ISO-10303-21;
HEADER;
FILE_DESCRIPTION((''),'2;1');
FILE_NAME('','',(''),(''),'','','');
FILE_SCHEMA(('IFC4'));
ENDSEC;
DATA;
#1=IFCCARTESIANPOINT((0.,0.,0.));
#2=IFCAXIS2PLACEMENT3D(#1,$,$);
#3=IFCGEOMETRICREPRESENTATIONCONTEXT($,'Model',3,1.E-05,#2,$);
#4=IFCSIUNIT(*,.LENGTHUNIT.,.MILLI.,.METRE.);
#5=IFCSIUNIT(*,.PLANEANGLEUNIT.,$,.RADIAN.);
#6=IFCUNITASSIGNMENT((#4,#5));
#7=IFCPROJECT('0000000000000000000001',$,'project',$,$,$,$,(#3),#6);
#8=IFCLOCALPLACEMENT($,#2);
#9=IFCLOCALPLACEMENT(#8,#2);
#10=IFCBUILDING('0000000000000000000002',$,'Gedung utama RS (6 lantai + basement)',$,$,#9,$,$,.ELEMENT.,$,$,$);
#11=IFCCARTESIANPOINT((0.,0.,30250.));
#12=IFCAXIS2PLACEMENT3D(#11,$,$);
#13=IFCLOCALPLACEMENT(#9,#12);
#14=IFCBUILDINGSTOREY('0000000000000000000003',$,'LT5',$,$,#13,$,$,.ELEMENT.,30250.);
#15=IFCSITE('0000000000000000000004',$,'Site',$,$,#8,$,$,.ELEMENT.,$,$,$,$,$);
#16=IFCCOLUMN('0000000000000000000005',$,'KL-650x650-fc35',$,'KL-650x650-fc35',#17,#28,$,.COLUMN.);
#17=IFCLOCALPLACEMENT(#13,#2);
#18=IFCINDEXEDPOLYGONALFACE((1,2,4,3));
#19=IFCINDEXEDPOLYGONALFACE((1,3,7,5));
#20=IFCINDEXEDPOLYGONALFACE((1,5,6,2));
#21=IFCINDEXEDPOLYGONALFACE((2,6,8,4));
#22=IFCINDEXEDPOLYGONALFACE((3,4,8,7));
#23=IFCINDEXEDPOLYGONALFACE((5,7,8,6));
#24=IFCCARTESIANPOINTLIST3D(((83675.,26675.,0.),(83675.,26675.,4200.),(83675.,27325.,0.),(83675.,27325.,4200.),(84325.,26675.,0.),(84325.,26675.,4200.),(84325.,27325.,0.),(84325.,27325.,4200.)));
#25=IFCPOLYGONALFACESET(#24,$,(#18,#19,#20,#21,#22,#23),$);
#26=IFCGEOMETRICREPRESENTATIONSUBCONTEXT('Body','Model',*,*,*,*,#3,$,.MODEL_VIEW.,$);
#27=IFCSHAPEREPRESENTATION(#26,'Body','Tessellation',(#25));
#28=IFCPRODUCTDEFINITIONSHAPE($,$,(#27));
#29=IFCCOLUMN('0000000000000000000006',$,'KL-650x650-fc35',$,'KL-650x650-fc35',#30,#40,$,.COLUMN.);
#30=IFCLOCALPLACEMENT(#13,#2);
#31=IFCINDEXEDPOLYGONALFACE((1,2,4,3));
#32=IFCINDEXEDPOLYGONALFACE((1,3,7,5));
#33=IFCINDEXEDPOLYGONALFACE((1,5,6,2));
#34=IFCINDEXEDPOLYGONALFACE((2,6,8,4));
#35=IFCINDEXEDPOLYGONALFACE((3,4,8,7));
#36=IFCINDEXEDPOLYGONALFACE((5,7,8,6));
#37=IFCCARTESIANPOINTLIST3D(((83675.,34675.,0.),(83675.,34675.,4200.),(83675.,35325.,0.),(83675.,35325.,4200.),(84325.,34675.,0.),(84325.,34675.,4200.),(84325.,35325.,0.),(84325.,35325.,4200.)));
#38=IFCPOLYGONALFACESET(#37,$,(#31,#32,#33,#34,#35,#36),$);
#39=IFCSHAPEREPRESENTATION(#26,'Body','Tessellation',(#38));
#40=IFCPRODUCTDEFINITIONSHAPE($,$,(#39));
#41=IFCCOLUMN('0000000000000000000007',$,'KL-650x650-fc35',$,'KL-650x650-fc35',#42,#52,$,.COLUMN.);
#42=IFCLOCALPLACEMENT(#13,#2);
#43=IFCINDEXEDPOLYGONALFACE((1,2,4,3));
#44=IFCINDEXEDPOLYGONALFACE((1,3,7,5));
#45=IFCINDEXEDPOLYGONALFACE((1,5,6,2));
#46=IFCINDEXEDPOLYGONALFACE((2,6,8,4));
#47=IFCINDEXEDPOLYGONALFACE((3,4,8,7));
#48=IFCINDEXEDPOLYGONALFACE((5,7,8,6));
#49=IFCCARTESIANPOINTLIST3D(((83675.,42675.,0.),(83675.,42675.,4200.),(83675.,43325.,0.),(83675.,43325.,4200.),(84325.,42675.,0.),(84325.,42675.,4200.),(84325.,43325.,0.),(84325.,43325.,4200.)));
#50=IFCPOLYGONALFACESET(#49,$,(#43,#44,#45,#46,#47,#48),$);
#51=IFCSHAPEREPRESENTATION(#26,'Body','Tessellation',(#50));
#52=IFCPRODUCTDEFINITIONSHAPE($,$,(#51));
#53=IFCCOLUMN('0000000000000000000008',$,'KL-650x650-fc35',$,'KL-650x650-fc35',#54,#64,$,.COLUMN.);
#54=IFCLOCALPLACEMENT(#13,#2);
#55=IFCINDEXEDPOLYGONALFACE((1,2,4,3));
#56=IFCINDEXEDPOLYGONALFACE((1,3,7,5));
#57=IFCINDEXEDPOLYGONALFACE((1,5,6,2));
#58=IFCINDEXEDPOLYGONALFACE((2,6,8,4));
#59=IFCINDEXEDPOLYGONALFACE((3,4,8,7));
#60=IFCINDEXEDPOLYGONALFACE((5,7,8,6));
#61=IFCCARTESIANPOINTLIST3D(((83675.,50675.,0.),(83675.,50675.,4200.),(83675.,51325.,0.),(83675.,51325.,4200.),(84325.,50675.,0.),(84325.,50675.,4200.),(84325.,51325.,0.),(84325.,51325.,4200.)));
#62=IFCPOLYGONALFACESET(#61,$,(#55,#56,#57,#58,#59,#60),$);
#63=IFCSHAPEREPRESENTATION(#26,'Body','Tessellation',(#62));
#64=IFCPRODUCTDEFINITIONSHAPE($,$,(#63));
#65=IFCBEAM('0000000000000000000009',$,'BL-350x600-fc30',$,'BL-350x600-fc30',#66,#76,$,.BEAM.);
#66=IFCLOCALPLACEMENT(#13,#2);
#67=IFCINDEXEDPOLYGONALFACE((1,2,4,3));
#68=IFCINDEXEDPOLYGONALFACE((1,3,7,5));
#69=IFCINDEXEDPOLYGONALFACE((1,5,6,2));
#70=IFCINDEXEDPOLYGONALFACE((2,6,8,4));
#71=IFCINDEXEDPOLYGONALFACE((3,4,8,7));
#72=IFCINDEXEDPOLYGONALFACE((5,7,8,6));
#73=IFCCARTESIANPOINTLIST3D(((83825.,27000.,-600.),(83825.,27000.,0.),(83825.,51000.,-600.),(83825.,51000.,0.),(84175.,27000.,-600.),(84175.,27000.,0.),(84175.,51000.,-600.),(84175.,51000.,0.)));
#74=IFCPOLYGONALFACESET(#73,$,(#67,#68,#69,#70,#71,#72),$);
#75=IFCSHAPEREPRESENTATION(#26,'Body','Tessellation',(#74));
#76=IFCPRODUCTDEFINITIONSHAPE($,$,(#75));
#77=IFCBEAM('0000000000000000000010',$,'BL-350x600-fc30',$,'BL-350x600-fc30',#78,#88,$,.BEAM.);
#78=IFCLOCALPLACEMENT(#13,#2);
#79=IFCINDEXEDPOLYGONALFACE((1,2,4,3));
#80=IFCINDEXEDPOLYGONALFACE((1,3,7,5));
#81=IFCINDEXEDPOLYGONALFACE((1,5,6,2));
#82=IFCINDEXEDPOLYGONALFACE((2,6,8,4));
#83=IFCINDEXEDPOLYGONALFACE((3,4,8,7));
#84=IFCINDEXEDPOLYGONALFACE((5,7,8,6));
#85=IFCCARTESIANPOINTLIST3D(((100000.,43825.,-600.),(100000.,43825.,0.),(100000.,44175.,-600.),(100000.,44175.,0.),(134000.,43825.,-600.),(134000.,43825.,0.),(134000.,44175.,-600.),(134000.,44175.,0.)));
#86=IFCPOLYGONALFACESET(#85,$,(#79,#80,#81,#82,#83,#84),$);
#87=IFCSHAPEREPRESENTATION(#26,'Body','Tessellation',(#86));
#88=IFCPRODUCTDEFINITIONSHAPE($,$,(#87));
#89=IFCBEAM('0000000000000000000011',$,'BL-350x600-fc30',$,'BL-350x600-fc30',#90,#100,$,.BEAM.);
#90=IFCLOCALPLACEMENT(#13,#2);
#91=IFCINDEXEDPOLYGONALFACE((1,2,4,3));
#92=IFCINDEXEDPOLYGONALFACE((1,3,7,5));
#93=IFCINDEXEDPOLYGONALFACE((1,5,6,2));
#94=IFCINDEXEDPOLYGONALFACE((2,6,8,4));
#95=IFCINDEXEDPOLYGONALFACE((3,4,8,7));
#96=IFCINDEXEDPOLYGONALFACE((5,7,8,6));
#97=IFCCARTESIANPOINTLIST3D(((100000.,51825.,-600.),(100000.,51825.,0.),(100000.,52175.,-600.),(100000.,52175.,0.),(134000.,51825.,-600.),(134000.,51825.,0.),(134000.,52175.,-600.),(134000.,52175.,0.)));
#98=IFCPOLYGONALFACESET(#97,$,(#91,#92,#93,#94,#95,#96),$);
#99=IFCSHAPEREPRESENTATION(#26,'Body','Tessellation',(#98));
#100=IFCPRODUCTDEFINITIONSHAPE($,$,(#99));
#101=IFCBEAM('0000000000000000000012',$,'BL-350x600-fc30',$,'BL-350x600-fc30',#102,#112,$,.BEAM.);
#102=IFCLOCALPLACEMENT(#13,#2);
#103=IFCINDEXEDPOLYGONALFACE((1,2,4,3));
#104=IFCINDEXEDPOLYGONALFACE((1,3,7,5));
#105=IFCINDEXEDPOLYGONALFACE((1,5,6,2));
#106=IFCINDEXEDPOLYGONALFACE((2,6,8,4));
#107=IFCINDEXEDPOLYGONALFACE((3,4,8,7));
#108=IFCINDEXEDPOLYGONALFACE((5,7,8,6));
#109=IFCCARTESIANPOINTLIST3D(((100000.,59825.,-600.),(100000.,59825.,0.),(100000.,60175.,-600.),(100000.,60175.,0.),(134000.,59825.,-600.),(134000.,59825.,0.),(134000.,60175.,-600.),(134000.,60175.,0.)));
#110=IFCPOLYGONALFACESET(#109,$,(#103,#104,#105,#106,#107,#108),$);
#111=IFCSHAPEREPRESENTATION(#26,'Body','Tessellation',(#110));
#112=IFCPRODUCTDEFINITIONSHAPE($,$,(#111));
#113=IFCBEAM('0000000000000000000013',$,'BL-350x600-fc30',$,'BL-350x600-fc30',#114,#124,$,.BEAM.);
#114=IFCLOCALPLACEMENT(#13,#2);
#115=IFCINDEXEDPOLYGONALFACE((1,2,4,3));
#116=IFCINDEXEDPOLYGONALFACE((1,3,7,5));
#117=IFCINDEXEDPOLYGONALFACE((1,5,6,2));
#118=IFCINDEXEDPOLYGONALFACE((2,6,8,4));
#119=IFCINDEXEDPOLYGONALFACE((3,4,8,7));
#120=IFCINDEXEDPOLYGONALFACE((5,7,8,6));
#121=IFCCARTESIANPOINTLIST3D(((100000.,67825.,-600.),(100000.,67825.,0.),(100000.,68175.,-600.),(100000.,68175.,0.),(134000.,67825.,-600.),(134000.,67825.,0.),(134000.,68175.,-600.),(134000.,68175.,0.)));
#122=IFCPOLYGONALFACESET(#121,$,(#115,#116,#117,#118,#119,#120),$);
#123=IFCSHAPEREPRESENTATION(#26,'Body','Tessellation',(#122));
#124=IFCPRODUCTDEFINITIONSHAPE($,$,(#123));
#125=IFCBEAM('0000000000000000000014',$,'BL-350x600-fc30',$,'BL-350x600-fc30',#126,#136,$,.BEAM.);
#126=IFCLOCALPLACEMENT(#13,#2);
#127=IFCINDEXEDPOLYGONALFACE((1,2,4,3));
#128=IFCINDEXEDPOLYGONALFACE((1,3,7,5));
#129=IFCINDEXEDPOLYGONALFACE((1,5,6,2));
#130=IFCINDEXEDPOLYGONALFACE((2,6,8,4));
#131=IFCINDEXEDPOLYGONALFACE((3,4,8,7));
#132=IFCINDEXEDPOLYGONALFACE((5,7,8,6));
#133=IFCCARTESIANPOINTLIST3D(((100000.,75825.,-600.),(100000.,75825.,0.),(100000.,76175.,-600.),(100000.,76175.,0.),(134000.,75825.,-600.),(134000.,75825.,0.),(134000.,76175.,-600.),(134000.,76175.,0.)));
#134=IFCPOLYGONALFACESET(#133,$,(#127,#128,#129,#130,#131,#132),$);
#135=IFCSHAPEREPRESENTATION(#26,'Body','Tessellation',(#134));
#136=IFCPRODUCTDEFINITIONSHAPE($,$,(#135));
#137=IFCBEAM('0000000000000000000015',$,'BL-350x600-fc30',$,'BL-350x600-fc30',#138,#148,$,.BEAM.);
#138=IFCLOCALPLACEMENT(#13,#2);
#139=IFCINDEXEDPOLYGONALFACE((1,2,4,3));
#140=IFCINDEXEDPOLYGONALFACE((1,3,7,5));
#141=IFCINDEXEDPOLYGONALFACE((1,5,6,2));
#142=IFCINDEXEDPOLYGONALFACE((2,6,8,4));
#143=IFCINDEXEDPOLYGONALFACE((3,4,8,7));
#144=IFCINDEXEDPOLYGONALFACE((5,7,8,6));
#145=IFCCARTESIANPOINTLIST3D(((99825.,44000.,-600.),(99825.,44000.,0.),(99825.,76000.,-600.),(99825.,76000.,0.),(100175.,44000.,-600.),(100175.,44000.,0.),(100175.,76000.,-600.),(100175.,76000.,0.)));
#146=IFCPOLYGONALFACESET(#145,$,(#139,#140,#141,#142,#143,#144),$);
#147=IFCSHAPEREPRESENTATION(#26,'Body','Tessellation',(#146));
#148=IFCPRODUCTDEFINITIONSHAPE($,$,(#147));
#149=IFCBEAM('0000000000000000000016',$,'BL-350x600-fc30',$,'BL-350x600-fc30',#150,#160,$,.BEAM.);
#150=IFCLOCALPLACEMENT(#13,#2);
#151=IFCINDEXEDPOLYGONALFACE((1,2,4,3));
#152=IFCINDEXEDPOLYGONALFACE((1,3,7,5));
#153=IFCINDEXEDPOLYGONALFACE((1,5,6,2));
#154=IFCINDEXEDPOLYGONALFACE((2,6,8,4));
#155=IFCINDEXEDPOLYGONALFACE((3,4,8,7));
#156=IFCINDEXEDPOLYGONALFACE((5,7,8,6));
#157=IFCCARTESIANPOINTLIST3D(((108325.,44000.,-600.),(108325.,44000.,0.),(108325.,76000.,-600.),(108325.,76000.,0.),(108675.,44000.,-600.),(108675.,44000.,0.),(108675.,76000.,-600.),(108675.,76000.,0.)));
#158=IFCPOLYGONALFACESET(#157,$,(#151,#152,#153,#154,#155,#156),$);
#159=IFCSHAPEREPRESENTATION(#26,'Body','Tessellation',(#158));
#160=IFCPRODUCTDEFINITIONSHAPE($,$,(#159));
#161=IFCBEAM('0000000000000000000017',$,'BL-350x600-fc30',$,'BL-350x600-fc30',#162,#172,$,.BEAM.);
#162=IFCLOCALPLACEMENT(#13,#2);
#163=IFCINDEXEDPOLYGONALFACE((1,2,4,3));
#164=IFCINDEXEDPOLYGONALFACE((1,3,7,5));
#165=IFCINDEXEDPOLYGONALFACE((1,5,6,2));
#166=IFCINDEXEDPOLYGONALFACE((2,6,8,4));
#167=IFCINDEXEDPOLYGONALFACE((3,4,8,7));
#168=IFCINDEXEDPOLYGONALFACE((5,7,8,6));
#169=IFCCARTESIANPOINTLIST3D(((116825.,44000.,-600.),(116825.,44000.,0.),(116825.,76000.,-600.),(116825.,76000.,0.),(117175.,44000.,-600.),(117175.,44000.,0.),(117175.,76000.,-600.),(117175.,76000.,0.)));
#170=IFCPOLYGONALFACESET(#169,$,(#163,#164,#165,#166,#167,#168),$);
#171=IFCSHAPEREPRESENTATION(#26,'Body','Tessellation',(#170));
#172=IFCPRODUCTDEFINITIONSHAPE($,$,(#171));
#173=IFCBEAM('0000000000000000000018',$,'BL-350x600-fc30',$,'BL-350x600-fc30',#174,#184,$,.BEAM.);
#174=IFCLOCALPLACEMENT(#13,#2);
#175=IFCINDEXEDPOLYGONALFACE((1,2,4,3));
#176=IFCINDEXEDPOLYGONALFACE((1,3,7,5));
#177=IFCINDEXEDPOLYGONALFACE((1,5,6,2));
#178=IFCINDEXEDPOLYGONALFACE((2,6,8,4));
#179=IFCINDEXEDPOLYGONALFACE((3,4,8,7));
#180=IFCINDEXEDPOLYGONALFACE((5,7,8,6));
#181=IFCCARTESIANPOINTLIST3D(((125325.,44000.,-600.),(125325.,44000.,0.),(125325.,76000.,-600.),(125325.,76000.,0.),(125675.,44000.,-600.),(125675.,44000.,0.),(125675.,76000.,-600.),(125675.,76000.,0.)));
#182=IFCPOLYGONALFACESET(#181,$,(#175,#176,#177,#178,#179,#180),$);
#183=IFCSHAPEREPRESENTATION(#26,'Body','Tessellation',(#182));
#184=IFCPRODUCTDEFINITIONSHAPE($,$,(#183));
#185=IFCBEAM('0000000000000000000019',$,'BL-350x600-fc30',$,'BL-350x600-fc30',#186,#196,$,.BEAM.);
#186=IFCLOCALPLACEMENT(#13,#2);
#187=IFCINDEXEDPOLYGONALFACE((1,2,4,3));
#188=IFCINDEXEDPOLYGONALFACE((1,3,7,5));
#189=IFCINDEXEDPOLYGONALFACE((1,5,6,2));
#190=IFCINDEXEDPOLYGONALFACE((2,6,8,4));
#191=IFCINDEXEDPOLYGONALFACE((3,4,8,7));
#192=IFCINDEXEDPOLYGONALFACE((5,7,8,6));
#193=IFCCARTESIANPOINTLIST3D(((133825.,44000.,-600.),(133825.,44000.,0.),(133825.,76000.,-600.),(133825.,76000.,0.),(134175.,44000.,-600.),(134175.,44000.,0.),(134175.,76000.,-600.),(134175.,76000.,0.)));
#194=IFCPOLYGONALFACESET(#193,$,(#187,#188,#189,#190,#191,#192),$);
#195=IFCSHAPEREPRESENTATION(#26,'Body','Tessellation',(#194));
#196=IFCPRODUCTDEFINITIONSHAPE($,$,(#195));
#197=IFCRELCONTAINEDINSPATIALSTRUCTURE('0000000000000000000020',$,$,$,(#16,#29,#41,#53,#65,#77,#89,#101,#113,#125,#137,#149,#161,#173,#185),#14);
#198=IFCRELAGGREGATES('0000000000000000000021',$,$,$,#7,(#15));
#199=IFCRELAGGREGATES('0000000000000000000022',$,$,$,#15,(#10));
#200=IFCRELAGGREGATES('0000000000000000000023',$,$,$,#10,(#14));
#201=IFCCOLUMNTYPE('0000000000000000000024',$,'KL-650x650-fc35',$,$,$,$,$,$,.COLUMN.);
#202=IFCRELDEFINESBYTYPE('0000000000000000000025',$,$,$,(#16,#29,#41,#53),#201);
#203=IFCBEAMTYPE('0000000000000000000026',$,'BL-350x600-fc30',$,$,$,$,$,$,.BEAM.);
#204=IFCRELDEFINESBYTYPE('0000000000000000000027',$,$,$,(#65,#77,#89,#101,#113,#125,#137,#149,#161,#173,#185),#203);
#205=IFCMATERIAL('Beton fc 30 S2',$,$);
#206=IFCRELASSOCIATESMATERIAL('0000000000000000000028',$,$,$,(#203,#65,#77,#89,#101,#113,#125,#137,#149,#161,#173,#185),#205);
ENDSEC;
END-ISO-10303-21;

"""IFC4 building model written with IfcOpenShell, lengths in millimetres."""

from ifc_helpers import new_model, si_unit, frame, origin, origin_2d, place, context, subcontext, project, spatial, rectangle, extrude, material, material_profile, profile_set, profile_usage, type_object, element, save


model = new_model("IFC4")

# Units and contexts
model_context = context("Model", 3, precision=1e-05, world=origin())
body_context = subcontext(model_context, "Body", "Model", "MODEL_VIEW")
ifc_project = project(units=[si_unit("LENGTHUNIT", "METRE", prefix="MILLI"), si_unit("PLANEANGLEUNIT", "RADIAN")], contexts=[model_context])

# Site, building, storey
site_placement = place(None, origin())
site = spatial("IfcSite", under=ifc_project, at=site_placement, Name="Site", CompositionType="ELEMENT")
building_placement = place(site_placement, origin())
building = spatial("IfcBuilding", under=site, at=building_placement, Name="Gedung utama RS (6 lantai + basement)", CompositionType="ELEMENT")
storey_placement = place(building_placement, frame((0.0, 0.0, 30250.0)))
storey = spatial("IfcBuildingStorey", under=building, at=storey_placement, Name="LT5", CompositionType="ELEMENT", Elevation=30250.0)

# Columns
ifc_material_profile_1 = material_profile(None, rectangle(XDim=650.0, YDim=650.0, at=origin_2d()), Name="KL-650x650-fc35")
ifc_profile_set_1 = profile_set([ifc_material_profile_1], Name="KL-650x650-fc35")
ifc_profile_usage_1 = profile_usage(ifc_profile_set_1, cardinal=5)
column_type = type_object("IfcColumnType", Name="KL-650x650-fc35", PredefinedType="COLUMN", material=ifc_profile_set_1)
for number, where, z_axis, x_axis, name in (
    (1, (84000.0, 27000.0, 0.0), (0.0, 0.0, 1.0), (1.0, 0.0, 0.0), "KL-650x650-fc35"),
    (2, (84000.0, 35000.0, 0.0), (0.0, 0.0, 1.0), (1.0, 0.0, 0.0), "KL-650x650-fc35"),
    (3, (84000.0, 43000.0, 0.0), (0.0, 0.0, 1.0), (1.0, 0.0, 0.0), "KL-650x650-fc35"),
    (4, (84000.0, 51000.0, 0.0), (0.0, 0.0, 1.0), (1.0, 0.0, 0.0), "KL-650x650-fc35"),
):
    element("IfcColumn", number, at=place(storey_placement, frame(where, z_axis=z_axis, x_axis=x_axis)), inside=storey, type_object=column_type, material=ifc_profile_usage_1, Name=name, ObjectType="KL-650x650-fc35", PredefinedType="COLUMN", context=body_context, shape_type="SweptSolid", body=[
        extrude(rectangle(XDim=650.0, YDim=650.0, at=origin_2d()), origin(), (0.0, 0.0, 1.0), 4200.0),
    ])

# Beams
ifc_material_1 = material(Name="Beton fc 30 S2")
ifc_material_profile_2 = material_profile(ifc_material_1, rectangle(XDim=350.0, YDim=600.0, at=origin_2d()), Name="BL-350x600-fc30")
ifc_profile_set_2 = profile_set([ifc_material_profile_2], Name="BL-350x600-fc30")
ifc_profile_usage_2 = profile_usage(ifc_profile_set_2, cardinal=8)
beam_type = type_object("IfcBeamType", Name="BL-350x600-fc30", PredefinedType="BEAM", material=ifc_profile_set_2)
beam_placement = place(storey_placement, frame((84000.0, 27000.0, -300.0)))
element("IfcBeam", 5, at=beam_placement, inside=storey, type_object=beam_type, material=ifc_profile_usage_2, Name="BL-350x600-fc30", ObjectType="BL-350x600-fc30", PredefinedType="BEAM", context=body_context, shape_type="SweptSolid", body=[
    extrude(rectangle(XDim=350.0, YDim=600.0, at=origin_2d()), frame((0.0, 0.0, 0.0), z_axis=(0.0, 1.0, 0.0), x_axis=(-1.0, 0.0, 0.0)), (0.0, 0.0, 1.0), 24000.0),
])
for number, where, name in (
    (6, (100000.0, 44000.0, -300.0), "BL-350x600-fc30"),
    (7, (100000.0, 52000.0, -300.0), "BL-350x600-fc30"),
    (8, (100000.0, 60000.0, -300.0), "BL-350x600-fc30"),
    (9, (100000.0, 68000.0, -300.0), "BL-350x600-fc30"),
    (10, (100000.0, 76000.0, -300.0), "BL-350x600-fc30"),
):
    element("IfcBeam", number, at=place(storey_placement, frame(where)), inside=storey, type_object=beam_type, material=ifc_profile_usage_2, Name=name, ObjectType="BL-350x600-fc30", PredefinedType="BEAM", context=body_context, shape_type="SweptSolid", body=[
        extrude(rectangle(XDim=350.0, YDim=600.0, at=origin_2d()), frame((0.0, 0.0, 0.0), z_axis=(1.0, 0.0, 0.0), x_axis=(0.0, 1.0, 0.0)), (0.0, 0.0, 1.0), 34000.0),
    ])
for number, where, name in (
    (11, (100000.0, 44000.0, -300.0), "BL-350x600-fc30"),
    (12, (108500.0, 44000.0, -300.0), "BL-350x600-fc30"),
    (13, (117000.0, 44000.0, -300.0), "BL-350x600-fc30"),
    (14, (125500.0, 44000.0, -300.0), "BL-350x600-fc30"),
    (15, (134000.0, 44000.0, -300.0), "BL-350x600-fc30"),
):
    element("IfcBeam", number, at=place(storey_placement, frame(where)), inside=storey, type_object=beam_type, material=ifc_profile_usage_2, Name=name, ObjectType="BL-350x600-fc30", PredefinedType="BEAM", context=body_context, shape_type="SweptSolid", body=[
        extrude(rectangle(XDim=350.0, YDim=600.0, at=origin_2d()), frame((0.0, 0.0, 0.0), z_axis=(0.0, 1.0, 0.0), x_axis=(-1.0, 0.0, 0.0)), (0.0, 0.0, 1.0), 32000.0),
    ])

save(model, "model.ifc")
